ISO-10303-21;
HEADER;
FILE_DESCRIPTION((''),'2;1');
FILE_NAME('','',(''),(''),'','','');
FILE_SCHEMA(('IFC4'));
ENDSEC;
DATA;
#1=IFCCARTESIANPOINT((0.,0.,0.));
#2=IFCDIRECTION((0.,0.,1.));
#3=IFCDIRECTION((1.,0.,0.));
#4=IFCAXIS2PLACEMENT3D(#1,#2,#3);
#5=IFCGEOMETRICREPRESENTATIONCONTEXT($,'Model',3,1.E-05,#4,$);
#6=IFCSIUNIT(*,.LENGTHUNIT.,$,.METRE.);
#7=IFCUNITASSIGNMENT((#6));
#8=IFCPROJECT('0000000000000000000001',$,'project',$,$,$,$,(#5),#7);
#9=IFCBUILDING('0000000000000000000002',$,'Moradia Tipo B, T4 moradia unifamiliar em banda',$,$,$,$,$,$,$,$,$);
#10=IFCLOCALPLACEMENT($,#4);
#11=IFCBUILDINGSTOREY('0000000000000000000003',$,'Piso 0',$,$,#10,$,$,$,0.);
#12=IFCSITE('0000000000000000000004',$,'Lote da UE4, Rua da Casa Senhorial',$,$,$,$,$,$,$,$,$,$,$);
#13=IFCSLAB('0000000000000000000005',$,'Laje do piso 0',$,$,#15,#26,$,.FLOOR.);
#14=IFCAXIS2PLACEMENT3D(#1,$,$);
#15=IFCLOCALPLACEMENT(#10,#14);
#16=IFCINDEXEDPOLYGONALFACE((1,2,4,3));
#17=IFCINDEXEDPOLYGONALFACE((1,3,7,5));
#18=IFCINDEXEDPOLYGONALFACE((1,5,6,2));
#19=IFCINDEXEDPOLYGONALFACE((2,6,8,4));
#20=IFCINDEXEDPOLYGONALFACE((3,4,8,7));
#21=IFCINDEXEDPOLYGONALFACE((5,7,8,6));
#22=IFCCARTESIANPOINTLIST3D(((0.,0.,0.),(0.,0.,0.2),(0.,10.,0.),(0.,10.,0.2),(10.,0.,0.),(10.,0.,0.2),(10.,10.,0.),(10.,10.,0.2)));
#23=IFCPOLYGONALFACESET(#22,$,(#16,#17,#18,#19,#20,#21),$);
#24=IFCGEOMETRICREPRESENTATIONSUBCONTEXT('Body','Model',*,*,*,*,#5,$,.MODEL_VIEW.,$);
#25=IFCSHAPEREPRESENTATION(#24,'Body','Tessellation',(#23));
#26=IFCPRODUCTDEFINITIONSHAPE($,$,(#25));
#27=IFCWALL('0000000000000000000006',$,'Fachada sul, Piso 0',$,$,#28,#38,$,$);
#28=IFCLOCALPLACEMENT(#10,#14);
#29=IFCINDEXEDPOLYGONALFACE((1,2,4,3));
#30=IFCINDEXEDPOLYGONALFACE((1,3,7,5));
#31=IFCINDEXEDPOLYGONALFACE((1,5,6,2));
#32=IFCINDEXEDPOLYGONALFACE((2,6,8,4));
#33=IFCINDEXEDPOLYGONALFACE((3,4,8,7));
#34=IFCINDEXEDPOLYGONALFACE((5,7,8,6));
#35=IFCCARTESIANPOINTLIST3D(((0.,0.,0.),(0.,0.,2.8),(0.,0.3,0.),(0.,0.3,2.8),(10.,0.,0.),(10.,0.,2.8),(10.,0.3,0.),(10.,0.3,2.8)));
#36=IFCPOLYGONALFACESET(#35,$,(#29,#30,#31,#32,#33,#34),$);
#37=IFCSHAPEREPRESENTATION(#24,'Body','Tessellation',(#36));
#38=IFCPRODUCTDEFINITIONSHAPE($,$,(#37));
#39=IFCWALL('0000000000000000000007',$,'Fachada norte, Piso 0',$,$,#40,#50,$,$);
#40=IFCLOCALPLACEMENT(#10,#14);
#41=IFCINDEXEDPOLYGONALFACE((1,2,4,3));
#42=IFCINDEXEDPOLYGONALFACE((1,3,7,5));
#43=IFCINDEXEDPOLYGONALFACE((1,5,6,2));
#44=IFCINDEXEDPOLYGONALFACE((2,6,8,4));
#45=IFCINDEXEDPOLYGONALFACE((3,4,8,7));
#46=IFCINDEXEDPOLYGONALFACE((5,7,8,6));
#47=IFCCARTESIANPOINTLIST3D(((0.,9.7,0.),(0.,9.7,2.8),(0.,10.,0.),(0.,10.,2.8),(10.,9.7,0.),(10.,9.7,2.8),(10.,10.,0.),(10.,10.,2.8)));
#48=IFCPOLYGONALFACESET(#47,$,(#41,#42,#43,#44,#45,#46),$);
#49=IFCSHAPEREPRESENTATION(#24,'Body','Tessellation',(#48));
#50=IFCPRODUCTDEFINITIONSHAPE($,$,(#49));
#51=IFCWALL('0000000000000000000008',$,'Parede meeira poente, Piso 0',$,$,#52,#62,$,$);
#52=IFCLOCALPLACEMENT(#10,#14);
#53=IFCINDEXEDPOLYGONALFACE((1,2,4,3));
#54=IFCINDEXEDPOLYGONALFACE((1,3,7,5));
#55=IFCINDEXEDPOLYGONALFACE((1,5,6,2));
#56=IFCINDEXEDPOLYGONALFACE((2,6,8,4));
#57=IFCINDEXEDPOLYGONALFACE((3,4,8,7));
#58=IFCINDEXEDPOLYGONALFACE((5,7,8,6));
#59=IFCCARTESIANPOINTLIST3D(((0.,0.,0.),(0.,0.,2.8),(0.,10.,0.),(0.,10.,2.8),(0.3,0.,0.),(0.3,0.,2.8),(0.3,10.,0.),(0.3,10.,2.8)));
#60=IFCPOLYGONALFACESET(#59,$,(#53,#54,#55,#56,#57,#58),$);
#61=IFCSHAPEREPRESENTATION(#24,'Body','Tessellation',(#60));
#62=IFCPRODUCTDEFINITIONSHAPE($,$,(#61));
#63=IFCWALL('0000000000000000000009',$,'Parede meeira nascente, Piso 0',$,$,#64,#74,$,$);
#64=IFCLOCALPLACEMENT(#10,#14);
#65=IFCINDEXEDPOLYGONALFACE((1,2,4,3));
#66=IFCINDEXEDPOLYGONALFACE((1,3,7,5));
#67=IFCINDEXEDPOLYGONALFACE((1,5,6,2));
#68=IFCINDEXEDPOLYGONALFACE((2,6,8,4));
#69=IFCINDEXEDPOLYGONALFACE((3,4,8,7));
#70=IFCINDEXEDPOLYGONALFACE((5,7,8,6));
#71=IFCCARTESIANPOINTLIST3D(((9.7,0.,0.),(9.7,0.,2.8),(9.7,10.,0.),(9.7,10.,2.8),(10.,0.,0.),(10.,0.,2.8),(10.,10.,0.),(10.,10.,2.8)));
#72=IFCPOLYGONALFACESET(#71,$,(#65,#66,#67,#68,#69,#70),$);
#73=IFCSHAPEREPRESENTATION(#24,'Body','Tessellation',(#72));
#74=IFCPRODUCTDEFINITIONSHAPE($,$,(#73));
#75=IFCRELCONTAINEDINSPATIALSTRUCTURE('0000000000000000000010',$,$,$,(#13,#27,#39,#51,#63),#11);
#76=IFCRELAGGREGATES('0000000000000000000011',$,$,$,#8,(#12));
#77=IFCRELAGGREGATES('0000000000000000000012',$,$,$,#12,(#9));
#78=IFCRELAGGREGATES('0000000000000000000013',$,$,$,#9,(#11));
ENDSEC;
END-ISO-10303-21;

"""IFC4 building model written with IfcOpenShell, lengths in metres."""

from ifc_helpers import new_model, si_unit, frame, origin_with_axes, place, context, subcontext, project, spatial, indexed_curve, outline, extrude, element, save


model = new_model("IFC4")

# Units and contexts
model_context = context("Model", 3, precision=1e-05, world=origin_with_axes())
body_context = subcontext(model_context, "Body", "Model", "MODEL_VIEW")
ifc_project = project(units=[si_unit("LENGTHUNIT", "METRE")], contexts=[model_context])

# Site, building, storey
site = spatial("IfcSite", under=ifc_project, Name="Lote da UE4, Rua da Casa Senhorial")
building = spatial("IfcBuilding", under=site, Name="Moradia Tipo B, T4 moradia unifamiliar em banda")
storey_placement = place(None, origin_with_axes())
storey = spatial("IfcBuildingStorey", under=building, at=storey_placement, Name="Piso 0", Elevation=0.0)

# Slab
slab_placement = place(storey_placement, origin_with_axes())
element("IfcSlab", 1, at=slab_placement, inside=storey, Name="Laje do piso 0", PredefinedType="FLOOR", context=body_context, shape_type="SweptSolid", body=[
    extrude(outline(indexed_curve([(0.0, 0.0), (10.0, 0.0), (10.0, 10.0), (0.0, 10.0), (0.0, 0.0)])), None, (0.0, 0.0, 1.0), 0.2),
])

# Walls
for number, where, z_axis, x_axis, name in (
    (2, (0.0, 0.0, 0.0), (0.0, 0.0, 1.0), (1.0, 0.0, 0.0), "Fachada sul, Piso 0"),
    (3, (0.0, 9.7, 0.0), (0.0, 0.0, 1.0), (1.0, 0.0, 0.0), "Fachada norte, Piso 0"),
    (4, (0.3, 0.0, 0.0), (0.0, 0.0, 1.0), (0.0, 1.0, 0.0), "Parede meeira poente, Piso 0"),
    (5, (10.0, 0.0, 0.0), (0.0, 0.0, 1.0), (0.0, 1.0, 0.0), "Parede meeira nascente, Piso 0"),
):
    element("IfcWall", number, at=place(storey_placement, frame(where, z_axis=z_axis, x_axis=x_axis)), inside=storey, Name=name, context=body_context, shape_type="SweptSolid", body=[
        extrude(outline(indexed_curve([(0.0, 0.0), (0.0, 0.3), (10.0, 0.3), (10.0, 0.0), (0.0, 0.0)], self_intersect=False)), origin_with_axes(), (0.0, 0.0, 1.0), 2.8),
    ])

save(model, "model.ifc")
